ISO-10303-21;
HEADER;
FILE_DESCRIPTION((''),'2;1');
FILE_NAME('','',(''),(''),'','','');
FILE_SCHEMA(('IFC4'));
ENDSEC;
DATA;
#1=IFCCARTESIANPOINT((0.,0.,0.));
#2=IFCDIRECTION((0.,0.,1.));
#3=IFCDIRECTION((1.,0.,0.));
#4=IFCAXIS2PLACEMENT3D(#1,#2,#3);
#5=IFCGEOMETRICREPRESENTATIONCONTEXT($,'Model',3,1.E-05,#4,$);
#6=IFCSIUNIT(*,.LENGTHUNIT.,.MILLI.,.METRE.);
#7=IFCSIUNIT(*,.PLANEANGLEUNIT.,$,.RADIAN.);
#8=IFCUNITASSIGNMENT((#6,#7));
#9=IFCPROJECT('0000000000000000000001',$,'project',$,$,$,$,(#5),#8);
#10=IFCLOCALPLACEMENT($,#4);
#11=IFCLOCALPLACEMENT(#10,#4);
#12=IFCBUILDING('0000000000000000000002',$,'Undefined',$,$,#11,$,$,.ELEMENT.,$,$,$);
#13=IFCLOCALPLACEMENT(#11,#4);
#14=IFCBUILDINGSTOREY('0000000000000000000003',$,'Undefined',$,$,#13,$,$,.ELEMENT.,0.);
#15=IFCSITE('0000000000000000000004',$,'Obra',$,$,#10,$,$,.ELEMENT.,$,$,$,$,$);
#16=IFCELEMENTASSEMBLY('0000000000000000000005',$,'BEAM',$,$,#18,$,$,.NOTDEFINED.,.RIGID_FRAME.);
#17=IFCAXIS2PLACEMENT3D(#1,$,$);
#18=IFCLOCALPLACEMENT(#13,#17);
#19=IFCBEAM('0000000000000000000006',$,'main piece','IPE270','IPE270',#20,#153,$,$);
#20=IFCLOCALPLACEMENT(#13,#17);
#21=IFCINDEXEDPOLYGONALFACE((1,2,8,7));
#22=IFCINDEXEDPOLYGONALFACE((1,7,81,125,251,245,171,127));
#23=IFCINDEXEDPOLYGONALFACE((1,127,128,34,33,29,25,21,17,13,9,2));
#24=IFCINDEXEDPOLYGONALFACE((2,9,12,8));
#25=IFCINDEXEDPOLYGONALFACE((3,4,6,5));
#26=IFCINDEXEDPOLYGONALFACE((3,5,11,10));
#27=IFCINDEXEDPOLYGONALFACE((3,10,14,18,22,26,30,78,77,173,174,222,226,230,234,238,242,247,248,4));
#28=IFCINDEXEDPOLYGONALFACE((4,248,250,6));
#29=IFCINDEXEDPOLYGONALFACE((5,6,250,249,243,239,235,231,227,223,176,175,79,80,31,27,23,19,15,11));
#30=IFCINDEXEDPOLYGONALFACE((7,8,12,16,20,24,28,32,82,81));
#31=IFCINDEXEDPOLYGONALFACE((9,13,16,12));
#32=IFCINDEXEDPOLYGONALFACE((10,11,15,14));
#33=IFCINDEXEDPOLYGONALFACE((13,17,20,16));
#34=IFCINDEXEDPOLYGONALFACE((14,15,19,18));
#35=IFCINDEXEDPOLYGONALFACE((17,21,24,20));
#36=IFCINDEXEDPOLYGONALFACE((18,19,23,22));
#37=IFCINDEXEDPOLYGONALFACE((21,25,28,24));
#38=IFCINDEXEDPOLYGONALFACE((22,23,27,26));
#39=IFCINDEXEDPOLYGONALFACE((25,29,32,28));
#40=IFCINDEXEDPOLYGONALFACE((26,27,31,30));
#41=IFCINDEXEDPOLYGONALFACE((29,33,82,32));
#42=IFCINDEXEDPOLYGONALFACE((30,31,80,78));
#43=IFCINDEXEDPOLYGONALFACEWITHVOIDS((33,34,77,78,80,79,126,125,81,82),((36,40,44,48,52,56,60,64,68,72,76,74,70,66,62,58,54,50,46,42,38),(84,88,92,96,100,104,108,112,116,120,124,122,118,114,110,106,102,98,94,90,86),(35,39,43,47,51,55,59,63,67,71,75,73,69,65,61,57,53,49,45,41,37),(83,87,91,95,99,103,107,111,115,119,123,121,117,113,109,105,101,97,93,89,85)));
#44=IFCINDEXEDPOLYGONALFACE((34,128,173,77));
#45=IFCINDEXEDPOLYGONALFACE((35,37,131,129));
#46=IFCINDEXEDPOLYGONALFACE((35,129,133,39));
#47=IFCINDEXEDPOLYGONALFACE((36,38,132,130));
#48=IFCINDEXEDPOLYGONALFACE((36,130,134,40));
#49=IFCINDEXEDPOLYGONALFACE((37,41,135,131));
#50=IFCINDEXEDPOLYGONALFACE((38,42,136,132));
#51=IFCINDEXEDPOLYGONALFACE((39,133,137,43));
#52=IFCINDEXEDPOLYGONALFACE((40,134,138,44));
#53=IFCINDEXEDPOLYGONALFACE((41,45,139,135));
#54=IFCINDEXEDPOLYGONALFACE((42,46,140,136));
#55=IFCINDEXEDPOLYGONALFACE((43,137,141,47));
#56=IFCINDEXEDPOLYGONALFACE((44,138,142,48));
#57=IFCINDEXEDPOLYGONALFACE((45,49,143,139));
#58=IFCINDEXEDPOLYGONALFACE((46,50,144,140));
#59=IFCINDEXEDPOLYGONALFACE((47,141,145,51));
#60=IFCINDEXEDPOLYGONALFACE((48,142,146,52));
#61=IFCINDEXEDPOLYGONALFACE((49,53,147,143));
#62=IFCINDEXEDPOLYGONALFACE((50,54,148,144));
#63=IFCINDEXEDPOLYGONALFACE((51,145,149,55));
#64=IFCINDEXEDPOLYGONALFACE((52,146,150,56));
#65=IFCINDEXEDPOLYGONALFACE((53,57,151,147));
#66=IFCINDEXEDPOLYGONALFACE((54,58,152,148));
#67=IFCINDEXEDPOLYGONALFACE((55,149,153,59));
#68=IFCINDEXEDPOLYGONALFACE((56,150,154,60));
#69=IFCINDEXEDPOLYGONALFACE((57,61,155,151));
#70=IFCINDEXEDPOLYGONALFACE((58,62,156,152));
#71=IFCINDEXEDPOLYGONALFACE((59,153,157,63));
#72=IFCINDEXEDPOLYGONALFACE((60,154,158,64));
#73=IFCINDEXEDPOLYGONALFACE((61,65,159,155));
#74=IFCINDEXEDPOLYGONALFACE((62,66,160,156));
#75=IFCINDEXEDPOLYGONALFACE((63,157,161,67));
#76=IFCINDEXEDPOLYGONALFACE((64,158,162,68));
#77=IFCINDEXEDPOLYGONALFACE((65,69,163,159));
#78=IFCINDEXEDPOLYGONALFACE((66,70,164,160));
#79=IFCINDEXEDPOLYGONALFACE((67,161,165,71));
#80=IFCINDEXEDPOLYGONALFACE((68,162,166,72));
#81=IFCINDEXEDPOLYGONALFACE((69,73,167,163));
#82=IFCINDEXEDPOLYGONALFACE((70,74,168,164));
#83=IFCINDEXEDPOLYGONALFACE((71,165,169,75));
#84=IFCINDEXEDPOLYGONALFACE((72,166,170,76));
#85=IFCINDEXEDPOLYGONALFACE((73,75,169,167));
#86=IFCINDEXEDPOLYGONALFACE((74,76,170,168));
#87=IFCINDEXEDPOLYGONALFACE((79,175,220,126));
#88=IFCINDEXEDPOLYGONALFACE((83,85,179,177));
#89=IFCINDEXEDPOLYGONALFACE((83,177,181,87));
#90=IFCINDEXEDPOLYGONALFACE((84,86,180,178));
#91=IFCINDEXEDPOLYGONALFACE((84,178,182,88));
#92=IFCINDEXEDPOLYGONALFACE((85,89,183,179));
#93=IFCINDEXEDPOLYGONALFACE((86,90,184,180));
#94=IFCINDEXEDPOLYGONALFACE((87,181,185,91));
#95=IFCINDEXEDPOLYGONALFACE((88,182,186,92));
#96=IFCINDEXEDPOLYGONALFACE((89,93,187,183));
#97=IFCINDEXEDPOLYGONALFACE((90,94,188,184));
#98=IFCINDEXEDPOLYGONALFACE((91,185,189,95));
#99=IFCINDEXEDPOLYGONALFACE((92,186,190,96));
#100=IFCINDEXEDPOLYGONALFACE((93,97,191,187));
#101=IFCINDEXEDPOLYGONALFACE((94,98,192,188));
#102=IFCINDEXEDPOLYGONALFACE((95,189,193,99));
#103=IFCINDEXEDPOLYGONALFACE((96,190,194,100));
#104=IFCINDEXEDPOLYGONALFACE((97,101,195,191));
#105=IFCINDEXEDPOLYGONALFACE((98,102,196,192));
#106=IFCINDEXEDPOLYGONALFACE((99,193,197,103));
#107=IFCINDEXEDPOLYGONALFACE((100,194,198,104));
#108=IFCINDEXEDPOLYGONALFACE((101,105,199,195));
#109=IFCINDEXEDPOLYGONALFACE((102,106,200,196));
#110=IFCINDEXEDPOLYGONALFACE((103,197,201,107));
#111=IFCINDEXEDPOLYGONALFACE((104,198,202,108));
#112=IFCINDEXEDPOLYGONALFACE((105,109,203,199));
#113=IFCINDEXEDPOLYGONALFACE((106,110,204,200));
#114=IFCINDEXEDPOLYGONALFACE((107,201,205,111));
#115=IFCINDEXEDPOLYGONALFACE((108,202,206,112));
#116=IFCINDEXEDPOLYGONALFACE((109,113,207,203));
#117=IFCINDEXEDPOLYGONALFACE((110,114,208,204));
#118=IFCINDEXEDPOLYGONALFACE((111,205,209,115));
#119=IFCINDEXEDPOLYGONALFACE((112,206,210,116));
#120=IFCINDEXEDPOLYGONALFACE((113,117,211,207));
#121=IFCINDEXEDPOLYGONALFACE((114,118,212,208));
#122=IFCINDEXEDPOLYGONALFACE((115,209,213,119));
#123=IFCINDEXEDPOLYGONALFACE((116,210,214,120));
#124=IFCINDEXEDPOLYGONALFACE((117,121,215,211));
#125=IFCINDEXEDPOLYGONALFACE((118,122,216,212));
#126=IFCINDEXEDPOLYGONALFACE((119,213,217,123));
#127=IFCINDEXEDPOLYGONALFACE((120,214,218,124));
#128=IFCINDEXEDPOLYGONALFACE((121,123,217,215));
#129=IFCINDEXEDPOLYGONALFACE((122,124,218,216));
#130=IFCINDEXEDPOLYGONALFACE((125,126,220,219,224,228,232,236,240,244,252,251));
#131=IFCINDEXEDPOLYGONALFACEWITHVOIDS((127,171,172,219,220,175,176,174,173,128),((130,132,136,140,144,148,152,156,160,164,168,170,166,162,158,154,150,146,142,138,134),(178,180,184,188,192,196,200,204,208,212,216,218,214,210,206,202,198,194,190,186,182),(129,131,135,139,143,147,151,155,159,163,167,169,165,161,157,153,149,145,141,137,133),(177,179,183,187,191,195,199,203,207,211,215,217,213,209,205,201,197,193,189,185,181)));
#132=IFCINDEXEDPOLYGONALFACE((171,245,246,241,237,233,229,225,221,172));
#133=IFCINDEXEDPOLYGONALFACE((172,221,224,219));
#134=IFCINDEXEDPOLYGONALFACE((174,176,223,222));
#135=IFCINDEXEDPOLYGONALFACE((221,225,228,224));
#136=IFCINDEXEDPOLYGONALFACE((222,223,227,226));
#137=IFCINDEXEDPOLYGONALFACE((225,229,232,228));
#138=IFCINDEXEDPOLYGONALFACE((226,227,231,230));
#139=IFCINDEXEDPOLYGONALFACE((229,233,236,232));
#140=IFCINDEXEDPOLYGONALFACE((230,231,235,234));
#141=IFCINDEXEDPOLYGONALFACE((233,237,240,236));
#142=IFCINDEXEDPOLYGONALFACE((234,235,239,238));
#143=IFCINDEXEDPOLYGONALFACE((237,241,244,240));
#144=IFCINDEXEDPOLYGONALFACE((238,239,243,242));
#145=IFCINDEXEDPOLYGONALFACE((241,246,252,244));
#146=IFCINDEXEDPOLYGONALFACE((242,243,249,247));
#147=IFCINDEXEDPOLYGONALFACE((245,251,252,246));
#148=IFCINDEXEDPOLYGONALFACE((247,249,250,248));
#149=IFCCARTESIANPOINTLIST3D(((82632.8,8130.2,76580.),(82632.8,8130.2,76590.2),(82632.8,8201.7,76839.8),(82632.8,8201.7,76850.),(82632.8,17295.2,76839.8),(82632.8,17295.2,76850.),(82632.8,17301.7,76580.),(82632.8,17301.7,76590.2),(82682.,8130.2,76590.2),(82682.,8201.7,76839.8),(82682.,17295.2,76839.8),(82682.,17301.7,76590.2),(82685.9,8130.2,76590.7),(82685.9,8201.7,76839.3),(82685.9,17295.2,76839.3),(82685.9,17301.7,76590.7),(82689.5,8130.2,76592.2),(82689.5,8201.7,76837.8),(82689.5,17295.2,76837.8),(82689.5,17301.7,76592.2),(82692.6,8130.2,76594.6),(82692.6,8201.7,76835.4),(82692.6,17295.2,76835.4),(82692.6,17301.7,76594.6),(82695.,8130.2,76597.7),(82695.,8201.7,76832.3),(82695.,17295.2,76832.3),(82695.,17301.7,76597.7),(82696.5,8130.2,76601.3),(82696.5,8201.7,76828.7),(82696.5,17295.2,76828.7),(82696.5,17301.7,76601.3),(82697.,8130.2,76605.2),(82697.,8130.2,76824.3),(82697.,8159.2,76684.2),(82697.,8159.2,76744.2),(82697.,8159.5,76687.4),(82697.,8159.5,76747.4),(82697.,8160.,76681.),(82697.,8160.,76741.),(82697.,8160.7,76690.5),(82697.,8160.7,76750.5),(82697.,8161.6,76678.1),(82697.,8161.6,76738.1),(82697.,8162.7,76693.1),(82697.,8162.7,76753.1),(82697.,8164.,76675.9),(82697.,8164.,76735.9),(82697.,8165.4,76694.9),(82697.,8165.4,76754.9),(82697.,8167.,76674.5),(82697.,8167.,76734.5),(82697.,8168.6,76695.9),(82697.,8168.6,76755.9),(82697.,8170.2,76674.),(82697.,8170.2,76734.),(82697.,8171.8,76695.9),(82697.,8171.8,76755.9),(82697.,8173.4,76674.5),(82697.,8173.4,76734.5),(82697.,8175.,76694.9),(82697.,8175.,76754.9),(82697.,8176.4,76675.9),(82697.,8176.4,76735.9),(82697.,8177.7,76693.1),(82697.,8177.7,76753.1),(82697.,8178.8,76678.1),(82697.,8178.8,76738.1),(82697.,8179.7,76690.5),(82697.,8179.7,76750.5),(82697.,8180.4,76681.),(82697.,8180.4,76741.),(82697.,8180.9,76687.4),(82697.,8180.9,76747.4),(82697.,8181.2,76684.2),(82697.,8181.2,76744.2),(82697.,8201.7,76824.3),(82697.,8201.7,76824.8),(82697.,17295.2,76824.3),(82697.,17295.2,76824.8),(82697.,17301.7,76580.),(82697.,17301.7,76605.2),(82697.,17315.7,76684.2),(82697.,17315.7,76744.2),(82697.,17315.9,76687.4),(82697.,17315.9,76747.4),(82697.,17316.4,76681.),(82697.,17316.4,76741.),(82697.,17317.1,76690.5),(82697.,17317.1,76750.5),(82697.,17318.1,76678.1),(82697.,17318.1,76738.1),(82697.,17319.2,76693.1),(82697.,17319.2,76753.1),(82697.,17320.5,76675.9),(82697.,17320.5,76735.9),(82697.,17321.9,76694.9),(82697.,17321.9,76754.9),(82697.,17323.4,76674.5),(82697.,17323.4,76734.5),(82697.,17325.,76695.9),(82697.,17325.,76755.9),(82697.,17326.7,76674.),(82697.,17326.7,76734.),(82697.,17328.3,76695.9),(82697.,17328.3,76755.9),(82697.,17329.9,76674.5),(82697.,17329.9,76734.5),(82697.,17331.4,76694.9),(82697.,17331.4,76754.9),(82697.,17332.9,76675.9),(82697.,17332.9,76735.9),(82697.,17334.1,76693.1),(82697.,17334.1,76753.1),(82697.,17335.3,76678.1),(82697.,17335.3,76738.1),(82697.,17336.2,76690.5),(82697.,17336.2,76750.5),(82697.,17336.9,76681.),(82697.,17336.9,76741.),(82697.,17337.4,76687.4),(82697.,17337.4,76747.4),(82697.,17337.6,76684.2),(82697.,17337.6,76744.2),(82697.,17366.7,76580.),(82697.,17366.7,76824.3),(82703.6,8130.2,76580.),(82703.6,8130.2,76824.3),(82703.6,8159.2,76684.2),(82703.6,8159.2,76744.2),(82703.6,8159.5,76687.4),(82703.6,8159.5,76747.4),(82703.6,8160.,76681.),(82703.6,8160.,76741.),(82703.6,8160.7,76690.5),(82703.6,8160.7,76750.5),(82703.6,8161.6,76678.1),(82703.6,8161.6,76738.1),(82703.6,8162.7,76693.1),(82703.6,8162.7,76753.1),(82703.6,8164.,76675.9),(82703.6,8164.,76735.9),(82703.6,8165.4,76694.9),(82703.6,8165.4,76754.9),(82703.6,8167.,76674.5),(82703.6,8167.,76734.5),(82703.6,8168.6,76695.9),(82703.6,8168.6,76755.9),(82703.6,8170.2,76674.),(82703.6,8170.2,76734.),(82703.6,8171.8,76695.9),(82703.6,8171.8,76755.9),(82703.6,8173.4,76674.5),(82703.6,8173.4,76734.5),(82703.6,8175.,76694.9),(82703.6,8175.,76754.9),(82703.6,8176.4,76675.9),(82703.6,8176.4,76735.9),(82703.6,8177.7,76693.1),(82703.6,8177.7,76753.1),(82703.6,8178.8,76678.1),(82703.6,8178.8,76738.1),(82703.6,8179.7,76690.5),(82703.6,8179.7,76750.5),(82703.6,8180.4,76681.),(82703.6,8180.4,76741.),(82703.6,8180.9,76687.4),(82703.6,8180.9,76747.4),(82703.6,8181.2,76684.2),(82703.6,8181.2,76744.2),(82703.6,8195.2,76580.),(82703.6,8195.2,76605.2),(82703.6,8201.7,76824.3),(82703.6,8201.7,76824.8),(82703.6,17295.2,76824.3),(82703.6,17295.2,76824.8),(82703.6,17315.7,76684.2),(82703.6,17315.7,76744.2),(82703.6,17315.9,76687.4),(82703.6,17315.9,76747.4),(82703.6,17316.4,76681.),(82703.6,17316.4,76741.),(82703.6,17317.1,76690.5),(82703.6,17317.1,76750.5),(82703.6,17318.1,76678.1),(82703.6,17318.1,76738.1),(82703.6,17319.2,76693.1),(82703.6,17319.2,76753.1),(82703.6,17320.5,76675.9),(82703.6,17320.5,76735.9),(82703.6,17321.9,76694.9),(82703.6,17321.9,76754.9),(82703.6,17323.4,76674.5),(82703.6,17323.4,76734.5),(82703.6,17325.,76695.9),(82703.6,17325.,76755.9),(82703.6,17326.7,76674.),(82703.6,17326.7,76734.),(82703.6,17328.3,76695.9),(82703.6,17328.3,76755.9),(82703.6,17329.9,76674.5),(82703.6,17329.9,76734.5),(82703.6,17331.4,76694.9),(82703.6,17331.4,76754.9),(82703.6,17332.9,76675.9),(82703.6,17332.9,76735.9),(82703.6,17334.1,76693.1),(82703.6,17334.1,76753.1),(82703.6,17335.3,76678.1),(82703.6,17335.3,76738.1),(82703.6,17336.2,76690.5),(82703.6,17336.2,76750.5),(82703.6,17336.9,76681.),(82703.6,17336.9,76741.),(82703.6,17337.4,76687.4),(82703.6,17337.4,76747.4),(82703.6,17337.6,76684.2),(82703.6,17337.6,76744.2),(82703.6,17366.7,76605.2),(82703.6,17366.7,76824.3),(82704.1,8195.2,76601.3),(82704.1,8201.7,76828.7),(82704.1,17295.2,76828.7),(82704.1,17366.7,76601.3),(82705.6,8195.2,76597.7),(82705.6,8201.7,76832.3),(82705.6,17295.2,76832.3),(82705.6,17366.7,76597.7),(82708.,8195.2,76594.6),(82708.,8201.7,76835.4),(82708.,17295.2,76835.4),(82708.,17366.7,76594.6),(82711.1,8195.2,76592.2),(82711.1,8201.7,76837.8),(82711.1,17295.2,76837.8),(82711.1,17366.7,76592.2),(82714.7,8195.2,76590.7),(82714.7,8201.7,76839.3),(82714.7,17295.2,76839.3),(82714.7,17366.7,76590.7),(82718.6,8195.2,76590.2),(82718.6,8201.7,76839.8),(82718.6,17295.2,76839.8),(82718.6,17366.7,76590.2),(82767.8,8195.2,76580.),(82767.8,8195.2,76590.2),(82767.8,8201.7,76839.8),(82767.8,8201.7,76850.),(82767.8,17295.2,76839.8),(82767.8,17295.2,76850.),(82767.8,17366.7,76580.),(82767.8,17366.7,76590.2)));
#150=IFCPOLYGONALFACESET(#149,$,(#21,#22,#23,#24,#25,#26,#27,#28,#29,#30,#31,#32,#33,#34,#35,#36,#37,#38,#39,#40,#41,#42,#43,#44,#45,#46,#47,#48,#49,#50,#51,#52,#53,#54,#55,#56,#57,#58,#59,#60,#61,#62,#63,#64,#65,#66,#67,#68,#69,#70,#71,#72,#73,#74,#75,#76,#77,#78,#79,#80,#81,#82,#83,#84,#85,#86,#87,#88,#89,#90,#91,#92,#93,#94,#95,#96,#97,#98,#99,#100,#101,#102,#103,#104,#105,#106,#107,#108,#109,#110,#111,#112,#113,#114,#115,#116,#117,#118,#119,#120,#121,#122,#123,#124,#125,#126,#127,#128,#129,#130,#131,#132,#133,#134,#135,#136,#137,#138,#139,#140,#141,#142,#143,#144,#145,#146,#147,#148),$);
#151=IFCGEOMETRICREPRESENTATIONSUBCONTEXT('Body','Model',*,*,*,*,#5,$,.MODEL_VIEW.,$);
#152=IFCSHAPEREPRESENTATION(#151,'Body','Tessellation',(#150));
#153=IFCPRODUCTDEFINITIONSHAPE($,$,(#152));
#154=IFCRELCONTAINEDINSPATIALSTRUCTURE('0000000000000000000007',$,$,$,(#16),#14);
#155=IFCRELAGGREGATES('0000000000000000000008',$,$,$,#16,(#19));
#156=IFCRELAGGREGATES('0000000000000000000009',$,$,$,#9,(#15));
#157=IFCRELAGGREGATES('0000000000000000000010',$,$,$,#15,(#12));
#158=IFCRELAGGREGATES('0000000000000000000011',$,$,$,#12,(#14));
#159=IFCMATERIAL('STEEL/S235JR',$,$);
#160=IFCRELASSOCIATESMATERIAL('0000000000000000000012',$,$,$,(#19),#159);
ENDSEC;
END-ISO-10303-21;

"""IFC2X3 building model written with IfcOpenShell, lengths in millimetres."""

from ifc_helpers import new_model, si_unit, frame, origin_with_axes, origin_2d_with_axis, place, context, subcontext, project, spatial, rectangle, circle, i_section, extrude, clip, halfspace, source, transform, mapped, material, element, aggregate, save


model = new_model("IFC2X3")

# Units and contexts
model_context = context("Model", 3, precision=1e-05, world=origin_with_axes())
body_context = subcontext(model_context, "Body", "Model", "MODEL_VIEW")
ifc_project = project(units=[si_unit("LENGTHUNIT", "METRE", prefix="MILLI"), si_unit("PLANEANGLEUNIT", "RADIAN")], contexts=[model_context])

# Site, building, storey
site_placement = place(None, origin_with_axes())
site = spatial("IfcSite", under=ifc_project, at=site_placement, Name="Obra", CompositionType="ELEMENT")
building_placement = place(site_placement, origin_with_axes())
building = spatial("IfcBuilding", under=site, at=building_placement, Name="Undefined", CompositionType="ELEMENT")
storey_placement = place(building_placement, origin_with_axes())
storey = spatial("IfcBuildingStorey", under=building, at=storey_placement, Name="Undefined", CompositionType="ELEMENT", Elevation=0.0)

# Shared definitions
ifc_material = material(Name="STEEL/S235JR")

# Shared definitions
shared_shape = source(origin_with_axes(), body_context, "Body", "SweptSolid", [
    extrude(circle(Radius=11.0, at=origin_2d_with_axis()), frame((0.0, -3.4, 0.0), z_axis=(0.0, 1.0, 0.0), x_axis=(1.0, 0.0, 0.0)), (0.0, 0.0, 1.0), 6.8),
])

# Element assembly, beam, openings
assembly_1_placement = place(storey_placement, origin_with_axes())
assembly_1 = element("IfcElementAssembly", 1, at=assembly_1_placement, inside=storey, Name="BEAM", AssemblyPlace="NOTDEFINED", PredefinedType="RIGID_FRAME")
beam_1_placement = place(assembly_1_placement, frame((82700.3, 17285.2, 76715.0), z_axis=(0.0, 0.0, 1.0), x_axis=(0.0, -1.0, 0.0)))
beam_1 = element("IfcBeam", 2, at=beam_1_placement, material=ifc_material, Name="main piece", Description="IPE270", ObjectType="IPE270", context=body_context, shape_type="Clipping", body=[
    clip(clip(extrude(i_section(OverallWidth=135.0, OverallDepth=270.0, WebThickness=6.6, FlangeThickness=10.2, FilletRadius=15.0, at=origin_2d_with_axis()), frame((9155.0, 0.0, 0.0), z_axis=(-1.0, 0.0, 0.0), x_axis=(0.0, -1.0, 0.0)), (0.0, 0.0, 1.0), 9236.5), halfspace(frame((9155.0, 0.0, -235.0), z_axis=(-1.0, 0.0, 0.0), x_axis=(0.0, 1.0, 0.0)), True)), halfspace(frame((-81.5, 0.0, -235.0), z_axis=(1.0, 0.0, 0.0), x_axis=(0.0, -1.0, 0.0)), True)),
])
opening_1_placement = place(assembly_1_placement, frame((82700.3, 17285.2, 76715.0), z_axis=(0.0, 0.0, 1.0), x_axis=(0.0, -1.0, 0.0)))
element("IfcOpeningElement", 3, at=opening_1_placement, cuts=beam_1, ObjectType="Recess", context=body_context, shape_type="SweptSolid", body=[
    extrude(rectangle(XDim=75.0, YDim=300.0, at=origin_2d_with_axis()), frame((-54.0, -153.3, 124.3), z_axis=(0.0, 0.0, -1.0), x_axis=(1.0, 0.0, 0.0)), (0.0, 0.0, 1.0), 278.6),
])
opening_2_placement = place(assembly_1_placement, frame((82700.3, 17285.2, 76715.0), z_axis=(0.0, 0.0, 1.0), x_axis=(0.0, -1.0, 0.0)))
element("IfcOpeningElement", 4, at=opening_2_placement, cuts=beam_1, ObjectType="Recess", context=body_context, shape_type="SweptSolid", body=[
    extrude(rectangle(XDim=26.7, YDim=83.5, at=origin_2d_with_axis()), frame((-51.7, -68.5, 122.7), z_axis=(0.0, 1.0, 0.0), x_axis=(0.0, 0.0, -1.0)), (0.0, 0.0, 1.0), 137.0),
])
opening_3_placement = place(assembly_1_placement, frame((82700.3, 17285.2, 76715.0), z_axis=(0.0, 0.0, 1.0), x_axis=(0.0, -1.0, 0.0)))
element("IfcOpeningElement", 5, at=opening_3_placement, cuts=beam_1, ObjectType="Recess", context=body_context, shape_type="SweptSolid", body=[
    extrude(rectangle(XDim=75.0, YDim=300.0, at=origin_2d_with_axis()), frame((9127.5, 153.3, 124.3), z_axis=(0.0, 0.0, -1.0), x_axis=(-1.0, 0.0, 0.0)), (0.0, 0.0, 1.0), 278.6),
])
opening_4_placement = place(assembly_1_placement, frame((82700.3, 17285.2, 76715.0), z_axis=(0.0, 0.0, 1.0), x_axis=(0.0, -1.0, 0.0)))
element("IfcOpeningElement", 6, at=opening_4_placement, cuts=beam_1, ObjectType="Recess", context=body_context, shape_type="SweptSolid", body=[
    extrude(rectangle(XDim=26.7, YDim=83.5, at=origin_2d_with_axis()), frame((9125.3, 68.5, 122.7), z_axis=(0.0, -1.0, 0.0), x_axis=(0.0, 0.0, -1.0)), (0.0, 0.0, 1.0), 137.0),
])
opening_5_placement = place(assembly_1_placement, frame((82700.3, 17366.7, 76850.0), z_axis=(0.0, -1.0, 0.0), x_axis=(0.0, 0.0, -1.0)))
element("IfcOpeningElement", 7, at=opening_5_placement, cuts=beam_1, ObjectType="Opening", context=body_context, shape_type="MappedRepresentation", body=[
    mapped(shared_shape, transform((105.0, 0.0, 40.0))),
    mapped(shared_shape, transform((165.0, 0.0, 40.0))),
])
opening_6_placement = place(assembly_1_placement, frame((82700.3, 8130.2, 76850.0), z_axis=(0.0, 1.0, 0.0), x_axis=(0.0, 0.0, -1.0)))
element("IfcOpeningElement", 8, at=opening_6_placement, cuts=beam_1, ObjectType="Opening", context=body_context, shape_type="MappedRepresentation", body=[
    mapped(shared_shape, transform((105.0, 0.0, 40.0))),
    mapped(shared_shape, transform((165.0, 0.0, 40.0))),
])
aggregate(assembly_1, [beam_1])

save(model, "model.ifc")
